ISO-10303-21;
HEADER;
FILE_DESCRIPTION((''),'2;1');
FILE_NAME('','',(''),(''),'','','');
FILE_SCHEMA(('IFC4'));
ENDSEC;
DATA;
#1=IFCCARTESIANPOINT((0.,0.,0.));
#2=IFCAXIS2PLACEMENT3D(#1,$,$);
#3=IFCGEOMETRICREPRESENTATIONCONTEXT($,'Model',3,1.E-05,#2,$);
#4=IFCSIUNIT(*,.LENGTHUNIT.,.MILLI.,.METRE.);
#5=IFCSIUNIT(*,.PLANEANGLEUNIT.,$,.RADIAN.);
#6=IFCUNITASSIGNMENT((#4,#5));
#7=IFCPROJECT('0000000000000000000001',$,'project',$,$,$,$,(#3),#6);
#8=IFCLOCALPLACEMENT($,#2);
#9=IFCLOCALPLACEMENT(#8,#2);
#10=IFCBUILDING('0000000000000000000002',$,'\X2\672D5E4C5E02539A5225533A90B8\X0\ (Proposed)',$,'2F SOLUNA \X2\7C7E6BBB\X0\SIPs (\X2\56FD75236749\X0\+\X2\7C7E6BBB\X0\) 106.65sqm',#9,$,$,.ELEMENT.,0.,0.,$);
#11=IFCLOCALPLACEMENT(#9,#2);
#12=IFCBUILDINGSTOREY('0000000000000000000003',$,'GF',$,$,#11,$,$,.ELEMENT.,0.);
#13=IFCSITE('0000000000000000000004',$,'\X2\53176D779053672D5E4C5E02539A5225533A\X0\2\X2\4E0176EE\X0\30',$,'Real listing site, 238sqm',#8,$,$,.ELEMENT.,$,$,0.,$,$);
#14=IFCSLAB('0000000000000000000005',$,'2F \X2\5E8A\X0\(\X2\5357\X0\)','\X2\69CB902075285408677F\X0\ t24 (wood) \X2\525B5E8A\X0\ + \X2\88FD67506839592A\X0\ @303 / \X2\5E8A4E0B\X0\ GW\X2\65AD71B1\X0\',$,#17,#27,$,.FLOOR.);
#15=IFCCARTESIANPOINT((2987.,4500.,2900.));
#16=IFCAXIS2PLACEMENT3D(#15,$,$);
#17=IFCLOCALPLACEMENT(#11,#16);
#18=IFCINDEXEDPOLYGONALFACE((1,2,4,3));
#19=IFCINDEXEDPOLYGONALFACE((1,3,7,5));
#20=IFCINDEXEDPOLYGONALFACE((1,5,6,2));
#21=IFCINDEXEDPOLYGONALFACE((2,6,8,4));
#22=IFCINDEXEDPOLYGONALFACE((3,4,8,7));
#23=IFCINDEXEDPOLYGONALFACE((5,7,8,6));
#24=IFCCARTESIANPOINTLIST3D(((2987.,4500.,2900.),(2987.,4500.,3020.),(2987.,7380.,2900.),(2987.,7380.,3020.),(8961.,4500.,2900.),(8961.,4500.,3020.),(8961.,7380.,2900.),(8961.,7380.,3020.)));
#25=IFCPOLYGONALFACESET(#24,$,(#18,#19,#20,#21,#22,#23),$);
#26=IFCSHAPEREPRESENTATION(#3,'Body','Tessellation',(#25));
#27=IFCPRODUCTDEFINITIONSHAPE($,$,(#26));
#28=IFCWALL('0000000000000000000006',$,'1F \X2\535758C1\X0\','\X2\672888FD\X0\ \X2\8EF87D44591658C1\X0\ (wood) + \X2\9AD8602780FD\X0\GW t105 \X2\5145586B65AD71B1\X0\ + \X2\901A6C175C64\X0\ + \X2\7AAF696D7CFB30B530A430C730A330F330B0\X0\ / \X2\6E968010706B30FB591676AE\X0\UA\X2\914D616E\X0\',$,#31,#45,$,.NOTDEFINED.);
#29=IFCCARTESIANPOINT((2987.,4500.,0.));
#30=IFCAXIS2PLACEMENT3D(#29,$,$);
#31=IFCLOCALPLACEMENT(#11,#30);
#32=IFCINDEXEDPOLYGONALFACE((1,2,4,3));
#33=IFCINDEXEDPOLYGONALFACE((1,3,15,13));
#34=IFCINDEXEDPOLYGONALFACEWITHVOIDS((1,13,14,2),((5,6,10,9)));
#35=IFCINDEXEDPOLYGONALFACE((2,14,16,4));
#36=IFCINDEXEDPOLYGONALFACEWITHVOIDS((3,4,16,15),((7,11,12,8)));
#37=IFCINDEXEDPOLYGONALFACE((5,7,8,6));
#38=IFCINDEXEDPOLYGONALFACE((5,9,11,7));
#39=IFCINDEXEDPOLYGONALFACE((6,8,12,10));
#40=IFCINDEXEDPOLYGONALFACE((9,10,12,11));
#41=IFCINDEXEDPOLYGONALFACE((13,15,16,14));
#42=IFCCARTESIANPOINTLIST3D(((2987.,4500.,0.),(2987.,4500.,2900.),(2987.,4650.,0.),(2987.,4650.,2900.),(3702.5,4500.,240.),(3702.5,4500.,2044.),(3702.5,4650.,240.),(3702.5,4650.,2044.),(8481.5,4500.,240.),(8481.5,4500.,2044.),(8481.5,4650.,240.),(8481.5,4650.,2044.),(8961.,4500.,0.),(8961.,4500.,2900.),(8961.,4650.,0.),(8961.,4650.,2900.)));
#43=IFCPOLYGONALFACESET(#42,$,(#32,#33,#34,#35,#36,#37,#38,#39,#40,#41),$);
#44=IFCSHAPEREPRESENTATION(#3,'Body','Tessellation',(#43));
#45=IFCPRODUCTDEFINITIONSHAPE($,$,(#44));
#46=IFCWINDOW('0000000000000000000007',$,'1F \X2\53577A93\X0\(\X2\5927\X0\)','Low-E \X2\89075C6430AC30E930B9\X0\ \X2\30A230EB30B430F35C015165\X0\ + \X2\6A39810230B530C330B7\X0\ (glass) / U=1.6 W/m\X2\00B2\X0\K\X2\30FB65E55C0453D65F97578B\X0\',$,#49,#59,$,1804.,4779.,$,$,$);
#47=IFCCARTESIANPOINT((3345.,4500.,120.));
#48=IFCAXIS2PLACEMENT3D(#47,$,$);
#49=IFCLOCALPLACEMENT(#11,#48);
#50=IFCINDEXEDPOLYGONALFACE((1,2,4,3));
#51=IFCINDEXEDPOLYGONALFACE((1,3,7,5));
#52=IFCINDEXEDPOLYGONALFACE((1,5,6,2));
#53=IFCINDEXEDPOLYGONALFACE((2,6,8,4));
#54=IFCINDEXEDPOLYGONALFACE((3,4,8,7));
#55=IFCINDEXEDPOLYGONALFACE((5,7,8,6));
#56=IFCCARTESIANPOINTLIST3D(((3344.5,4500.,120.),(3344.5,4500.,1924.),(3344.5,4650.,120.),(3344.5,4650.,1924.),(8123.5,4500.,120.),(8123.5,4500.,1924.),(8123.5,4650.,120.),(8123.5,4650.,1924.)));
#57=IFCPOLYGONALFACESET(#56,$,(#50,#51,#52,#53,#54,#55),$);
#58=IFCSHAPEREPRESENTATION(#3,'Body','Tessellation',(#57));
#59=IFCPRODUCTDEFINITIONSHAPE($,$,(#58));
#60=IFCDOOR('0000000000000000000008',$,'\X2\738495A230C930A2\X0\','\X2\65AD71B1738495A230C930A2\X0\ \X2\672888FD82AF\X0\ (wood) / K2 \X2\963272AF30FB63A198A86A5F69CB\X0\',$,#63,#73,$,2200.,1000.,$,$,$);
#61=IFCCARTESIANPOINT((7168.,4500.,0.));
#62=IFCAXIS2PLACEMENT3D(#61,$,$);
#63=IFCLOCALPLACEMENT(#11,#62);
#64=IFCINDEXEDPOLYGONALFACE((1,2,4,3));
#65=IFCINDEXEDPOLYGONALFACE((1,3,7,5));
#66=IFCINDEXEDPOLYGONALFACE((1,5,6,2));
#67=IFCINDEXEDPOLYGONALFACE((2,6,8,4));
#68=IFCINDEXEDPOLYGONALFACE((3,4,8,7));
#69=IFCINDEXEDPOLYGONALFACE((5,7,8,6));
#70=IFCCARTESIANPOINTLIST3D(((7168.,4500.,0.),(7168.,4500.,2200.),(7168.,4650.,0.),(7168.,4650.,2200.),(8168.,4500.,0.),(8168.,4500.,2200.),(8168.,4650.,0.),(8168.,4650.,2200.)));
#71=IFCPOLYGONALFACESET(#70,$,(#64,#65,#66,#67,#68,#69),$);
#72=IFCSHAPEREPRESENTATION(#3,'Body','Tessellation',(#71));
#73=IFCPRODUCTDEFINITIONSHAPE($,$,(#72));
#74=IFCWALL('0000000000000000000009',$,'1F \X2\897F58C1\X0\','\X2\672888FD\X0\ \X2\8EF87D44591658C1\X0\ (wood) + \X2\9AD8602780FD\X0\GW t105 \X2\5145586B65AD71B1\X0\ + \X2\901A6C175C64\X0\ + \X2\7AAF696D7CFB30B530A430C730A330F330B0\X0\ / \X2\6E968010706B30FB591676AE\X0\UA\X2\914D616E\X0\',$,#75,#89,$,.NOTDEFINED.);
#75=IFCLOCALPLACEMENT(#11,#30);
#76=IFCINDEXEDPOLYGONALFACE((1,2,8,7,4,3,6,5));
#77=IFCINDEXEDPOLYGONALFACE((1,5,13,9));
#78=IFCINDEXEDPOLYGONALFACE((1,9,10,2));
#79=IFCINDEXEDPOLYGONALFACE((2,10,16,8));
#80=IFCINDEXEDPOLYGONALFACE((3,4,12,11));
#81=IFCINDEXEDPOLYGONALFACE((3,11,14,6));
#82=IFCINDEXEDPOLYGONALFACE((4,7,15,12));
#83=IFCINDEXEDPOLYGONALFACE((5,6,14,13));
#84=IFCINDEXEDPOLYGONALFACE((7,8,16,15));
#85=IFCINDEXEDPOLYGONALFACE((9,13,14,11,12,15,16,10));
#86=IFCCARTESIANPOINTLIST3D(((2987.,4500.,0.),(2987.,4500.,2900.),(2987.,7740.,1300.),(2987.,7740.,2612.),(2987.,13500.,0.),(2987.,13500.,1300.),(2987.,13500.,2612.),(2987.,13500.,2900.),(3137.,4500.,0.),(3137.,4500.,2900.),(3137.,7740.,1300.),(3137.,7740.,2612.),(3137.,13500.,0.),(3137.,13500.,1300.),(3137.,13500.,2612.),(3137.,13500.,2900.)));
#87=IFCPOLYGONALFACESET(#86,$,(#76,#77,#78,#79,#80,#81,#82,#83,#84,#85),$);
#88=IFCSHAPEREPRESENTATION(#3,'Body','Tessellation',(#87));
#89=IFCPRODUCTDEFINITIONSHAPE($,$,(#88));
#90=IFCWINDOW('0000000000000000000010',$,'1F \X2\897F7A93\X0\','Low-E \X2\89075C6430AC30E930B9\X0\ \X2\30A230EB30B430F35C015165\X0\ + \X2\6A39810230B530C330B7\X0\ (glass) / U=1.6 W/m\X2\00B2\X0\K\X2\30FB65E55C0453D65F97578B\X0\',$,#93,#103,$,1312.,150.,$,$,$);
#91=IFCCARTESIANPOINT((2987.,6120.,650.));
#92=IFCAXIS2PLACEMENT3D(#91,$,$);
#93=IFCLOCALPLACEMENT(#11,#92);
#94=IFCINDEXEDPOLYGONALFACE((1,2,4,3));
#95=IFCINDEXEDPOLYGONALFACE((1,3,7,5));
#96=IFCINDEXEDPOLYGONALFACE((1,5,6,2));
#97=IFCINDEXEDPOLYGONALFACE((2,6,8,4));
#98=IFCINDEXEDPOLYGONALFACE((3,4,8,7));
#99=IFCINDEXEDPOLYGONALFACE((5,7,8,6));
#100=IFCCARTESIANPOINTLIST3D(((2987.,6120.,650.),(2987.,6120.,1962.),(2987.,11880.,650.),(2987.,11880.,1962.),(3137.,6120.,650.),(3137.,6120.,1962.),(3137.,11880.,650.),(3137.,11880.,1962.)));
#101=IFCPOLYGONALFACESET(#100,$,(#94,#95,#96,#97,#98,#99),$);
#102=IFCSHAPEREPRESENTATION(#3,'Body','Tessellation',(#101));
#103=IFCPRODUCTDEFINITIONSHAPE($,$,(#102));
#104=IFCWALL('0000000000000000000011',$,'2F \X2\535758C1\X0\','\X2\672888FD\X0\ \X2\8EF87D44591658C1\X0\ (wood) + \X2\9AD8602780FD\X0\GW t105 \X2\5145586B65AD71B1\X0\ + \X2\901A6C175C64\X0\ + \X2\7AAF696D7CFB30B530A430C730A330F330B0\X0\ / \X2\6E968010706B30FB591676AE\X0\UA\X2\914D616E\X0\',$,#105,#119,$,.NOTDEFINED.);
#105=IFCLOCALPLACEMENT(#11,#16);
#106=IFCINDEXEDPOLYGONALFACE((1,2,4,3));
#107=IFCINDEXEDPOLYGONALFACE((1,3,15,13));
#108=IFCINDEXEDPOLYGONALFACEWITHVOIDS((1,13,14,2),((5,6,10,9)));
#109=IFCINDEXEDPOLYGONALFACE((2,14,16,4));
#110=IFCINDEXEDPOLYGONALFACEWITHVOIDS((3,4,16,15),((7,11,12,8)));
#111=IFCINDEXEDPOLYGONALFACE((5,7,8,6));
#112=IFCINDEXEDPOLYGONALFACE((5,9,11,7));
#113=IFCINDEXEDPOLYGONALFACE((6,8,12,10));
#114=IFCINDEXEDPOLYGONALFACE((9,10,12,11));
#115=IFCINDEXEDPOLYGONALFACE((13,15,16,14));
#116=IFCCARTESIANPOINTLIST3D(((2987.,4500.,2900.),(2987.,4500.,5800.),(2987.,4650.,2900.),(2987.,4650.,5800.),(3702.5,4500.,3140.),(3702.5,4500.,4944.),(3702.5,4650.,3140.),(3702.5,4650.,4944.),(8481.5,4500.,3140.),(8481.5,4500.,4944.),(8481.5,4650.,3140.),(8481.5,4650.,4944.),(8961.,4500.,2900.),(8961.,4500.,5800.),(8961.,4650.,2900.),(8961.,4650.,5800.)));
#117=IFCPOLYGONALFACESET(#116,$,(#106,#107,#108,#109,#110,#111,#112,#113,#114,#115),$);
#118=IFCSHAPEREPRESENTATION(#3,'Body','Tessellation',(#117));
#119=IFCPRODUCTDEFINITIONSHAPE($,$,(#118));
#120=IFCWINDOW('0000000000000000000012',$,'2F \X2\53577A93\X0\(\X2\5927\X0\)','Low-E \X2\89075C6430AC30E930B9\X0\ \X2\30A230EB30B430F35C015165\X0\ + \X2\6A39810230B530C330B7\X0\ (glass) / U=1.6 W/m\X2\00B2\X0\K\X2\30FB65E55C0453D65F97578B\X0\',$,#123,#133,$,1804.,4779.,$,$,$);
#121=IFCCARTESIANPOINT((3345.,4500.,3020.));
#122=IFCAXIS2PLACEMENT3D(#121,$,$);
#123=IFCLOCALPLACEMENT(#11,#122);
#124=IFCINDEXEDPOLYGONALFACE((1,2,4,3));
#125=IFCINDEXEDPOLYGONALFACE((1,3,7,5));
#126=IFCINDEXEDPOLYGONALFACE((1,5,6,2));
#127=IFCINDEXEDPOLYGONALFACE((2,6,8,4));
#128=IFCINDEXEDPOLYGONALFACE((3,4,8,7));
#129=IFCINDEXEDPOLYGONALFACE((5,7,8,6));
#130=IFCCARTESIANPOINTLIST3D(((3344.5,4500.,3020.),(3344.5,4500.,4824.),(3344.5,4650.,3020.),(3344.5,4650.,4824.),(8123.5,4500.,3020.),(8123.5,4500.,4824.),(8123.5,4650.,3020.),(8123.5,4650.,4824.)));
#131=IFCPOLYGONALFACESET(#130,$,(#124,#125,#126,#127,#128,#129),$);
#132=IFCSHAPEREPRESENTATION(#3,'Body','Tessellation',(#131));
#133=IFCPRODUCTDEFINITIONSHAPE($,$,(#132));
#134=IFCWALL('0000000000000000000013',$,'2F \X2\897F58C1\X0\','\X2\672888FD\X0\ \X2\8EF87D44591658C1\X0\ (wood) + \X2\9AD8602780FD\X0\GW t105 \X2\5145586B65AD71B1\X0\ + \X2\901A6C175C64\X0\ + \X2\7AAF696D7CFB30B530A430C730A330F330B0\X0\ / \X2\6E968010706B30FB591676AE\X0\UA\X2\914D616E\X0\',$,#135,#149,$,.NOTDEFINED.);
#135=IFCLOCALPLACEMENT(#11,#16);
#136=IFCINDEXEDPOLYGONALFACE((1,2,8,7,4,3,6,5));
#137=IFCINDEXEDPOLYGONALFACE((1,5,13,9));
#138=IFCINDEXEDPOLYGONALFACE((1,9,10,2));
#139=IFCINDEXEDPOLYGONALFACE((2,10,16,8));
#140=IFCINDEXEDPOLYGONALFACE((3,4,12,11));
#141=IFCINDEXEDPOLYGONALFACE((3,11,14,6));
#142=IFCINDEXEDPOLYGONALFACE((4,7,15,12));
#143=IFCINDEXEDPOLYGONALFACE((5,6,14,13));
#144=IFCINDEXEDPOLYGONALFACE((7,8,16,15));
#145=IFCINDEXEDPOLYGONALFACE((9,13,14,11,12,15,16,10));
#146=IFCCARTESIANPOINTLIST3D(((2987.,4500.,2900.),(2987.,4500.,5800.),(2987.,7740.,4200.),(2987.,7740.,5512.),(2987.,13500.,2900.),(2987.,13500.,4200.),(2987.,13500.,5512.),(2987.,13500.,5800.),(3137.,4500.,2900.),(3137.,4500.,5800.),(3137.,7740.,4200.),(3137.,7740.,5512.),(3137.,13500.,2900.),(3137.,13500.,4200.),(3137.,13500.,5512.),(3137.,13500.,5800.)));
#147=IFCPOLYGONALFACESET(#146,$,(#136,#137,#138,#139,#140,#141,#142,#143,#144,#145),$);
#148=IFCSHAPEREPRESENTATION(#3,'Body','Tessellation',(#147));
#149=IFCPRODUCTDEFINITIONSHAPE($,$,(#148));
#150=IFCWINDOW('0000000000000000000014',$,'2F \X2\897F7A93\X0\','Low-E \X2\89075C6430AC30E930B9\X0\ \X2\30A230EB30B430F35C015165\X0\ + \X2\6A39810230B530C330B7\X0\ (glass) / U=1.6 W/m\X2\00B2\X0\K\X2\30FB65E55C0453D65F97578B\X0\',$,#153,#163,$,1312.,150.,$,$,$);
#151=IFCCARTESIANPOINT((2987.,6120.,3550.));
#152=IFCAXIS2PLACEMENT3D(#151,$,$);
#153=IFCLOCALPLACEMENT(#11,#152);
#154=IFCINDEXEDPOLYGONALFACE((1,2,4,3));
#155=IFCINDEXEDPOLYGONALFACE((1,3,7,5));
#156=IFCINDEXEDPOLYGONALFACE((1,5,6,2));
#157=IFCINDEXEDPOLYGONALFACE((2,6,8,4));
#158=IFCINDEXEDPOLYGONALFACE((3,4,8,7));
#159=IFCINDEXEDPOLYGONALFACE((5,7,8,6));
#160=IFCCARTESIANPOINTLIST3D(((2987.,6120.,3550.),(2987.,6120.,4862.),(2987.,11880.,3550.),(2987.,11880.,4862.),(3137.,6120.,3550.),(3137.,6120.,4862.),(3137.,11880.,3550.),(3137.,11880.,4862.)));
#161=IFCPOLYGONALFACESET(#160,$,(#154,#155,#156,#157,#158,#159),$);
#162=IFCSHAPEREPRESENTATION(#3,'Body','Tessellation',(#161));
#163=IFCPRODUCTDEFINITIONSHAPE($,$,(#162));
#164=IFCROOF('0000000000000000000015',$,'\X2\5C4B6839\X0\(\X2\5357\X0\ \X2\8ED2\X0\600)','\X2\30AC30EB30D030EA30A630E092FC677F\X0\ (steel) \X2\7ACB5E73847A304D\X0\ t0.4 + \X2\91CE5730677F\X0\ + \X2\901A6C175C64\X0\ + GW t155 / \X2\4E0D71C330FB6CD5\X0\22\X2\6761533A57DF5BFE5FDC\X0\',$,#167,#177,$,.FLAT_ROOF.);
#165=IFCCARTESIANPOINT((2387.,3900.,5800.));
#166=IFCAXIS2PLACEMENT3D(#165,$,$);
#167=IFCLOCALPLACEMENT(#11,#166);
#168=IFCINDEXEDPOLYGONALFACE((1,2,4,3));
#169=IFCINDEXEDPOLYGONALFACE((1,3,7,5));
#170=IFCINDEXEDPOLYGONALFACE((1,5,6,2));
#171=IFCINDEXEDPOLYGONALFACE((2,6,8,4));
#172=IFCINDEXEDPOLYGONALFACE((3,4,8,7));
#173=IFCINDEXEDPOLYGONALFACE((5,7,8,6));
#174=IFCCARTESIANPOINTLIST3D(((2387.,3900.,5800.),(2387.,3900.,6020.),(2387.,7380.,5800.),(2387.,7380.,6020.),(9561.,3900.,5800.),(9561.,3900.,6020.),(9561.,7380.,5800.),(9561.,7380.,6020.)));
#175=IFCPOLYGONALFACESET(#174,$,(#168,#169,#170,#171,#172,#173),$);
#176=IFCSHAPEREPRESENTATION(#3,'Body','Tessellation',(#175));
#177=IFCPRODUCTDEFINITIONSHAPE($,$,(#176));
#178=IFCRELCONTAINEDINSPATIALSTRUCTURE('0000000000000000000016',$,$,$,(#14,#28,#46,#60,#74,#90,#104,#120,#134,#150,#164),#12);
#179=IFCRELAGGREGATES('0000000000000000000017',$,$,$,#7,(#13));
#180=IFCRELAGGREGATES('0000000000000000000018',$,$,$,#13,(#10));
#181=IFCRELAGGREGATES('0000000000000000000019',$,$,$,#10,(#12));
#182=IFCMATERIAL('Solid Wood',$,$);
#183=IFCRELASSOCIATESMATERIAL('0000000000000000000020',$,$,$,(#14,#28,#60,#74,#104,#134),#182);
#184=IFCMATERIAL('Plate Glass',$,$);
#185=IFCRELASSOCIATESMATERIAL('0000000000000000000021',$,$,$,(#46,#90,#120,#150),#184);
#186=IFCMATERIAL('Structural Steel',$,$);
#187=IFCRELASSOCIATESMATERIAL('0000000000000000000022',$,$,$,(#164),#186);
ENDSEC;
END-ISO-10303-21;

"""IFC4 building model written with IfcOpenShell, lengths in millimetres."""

from ifc_helpers import new_model, si_unit, frame, frame_2d, origin, place, context, project, spatial, rectangle, extrude, material, element, fill, save


model = new_model("IFC4")

# Units and contexts
model_context = context("Model", 3, precision=1e-05, world=origin())
ifc_project = project(units=[si_unit("LENGTHUNIT", "METRE", prefix="MILLI"), si_unit("PLANEANGLEUNIT", "RADIAN")], contexts=[model_context])

# Site, building, storey
site_placement = place(None, origin())
site = spatial("IfcSite", under=ifc_project, at=site_placement, Name="北海道札幌市厚別区2丁目30", ObjectType="Real listing site, 238sqm", CompositionType="ELEMENT", RefElevation=0.0)
building_placement = place(site_placement, origin())
building = spatial("IfcBuilding", under=site, at=building_placement, Name="札幌市厚別区邸 (Proposed)", ObjectType="2F SOLUNA 籾殻SIPs (国産杉+籾殻) 106.65sqm", CompositionType="ELEMENT", ElevationOfRefHeight=0.0, ElevationOfTerrain=0.0)
storey_placement = place(building_placement, origin())
storey = spatial("IfcBuildingStorey", under=building, at=storey_placement, Name="GF", CompositionType="ELEMENT", Elevation=0.0)

# Slab
ifc_material_1 = material(Name="Solid Wood")
slab_1_placement = place(storey_placement, frame((2987.0, 4500.0, 2900.0)))
element("IfcSlab", 1, at=slab_1_placement, inside=storey, material=ifc_material_1, Name="2F 床(南)", Description="構造用合板 t24 (wood) 剛床 + 製材根太 @303 / 床下 GW断熱", PredefinedType="FLOOR", context=model_context, shape_type="SweptSolid", body=[
    extrude(rectangle(XDim=5974.0, YDim=2880.0, at=frame_2d((2987.0, 1440.0))), frame((2987.0, 4500.0, 2900.0)), (0.0, 0.0, 1.0), 120.0),
])

# Wall, openings, window, door
wall_1_placement = place(storey_placement, frame((2987.0, 4500.0, 0.0)))
wall_1 = element("IfcWall", 2, at=wall_1_placement, inside=storey, material=ifc_material_1, Name="1F 南壁", Description="木製 軸組外壁 (wood) + 高性能GW t105 充填断熱 + 通気層 + 窯業系サイディング / 準耐火・外皮UA配慮", PredefinedType="NOTDEFINED", context=model_context, shape_type="SweptSolid", body=[
    extrude(rectangle(XDim=5974.0, YDim=150.0, at=frame_2d((2987.0, 75.0))), frame((2987.0, 4500.0, 0.0)), (0.0, 0.0, 1.0), 2900.0),
])
opening_1_placement = place(storey_placement, frame((3345.0, 4500.0, 120.0)))
opening_1 = element("IfcOpeningElement", 3, at=opening_1_placement, cuts=wall_1, PredefinedType="NOTDEFINED", context=model_context, shape_type="SweptSolid", body=[
    extrude(rectangle(XDim=4779.0, YDim=150.0, at=frame_2d((2389.0, 75.0))), frame((3345.0, 4500.0, 120.0)), (0.0, 0.0, 1.0), 1804.0),
])
opening_2_placement = place(storey_placement, frame((7168.0, 4500.0, 0.0)))
opening_2 = element("IfcOpeningElement", 4, at=opening_2_placement, cuts=wall_1, PredefinedType="NOTDEFINED", context=model_context, shape_type="SweptSolid", body=[
    extrude(rectangle(XDim=1000.0, YDim=150.0, at=frame_2d((500.0, 75.0))), frame((7168.0, 4500.0, 0.0)), (0.0, 0.0, 1.0), 2200.0),
])
ifc_material_2 = material(Name="Plate Glass")
window_1_placement = place(storey_placement, frame((3345.0, 4500.0, 120.0)))
window_1 = element("IfcWindow", 5, at=window_1_placement, inside=storey, material=ifc_material_2, Name="1F 南窓(大)", Description="Low-E 複層ガラス アルゴン封入 + 樹脂サッシ (glass) / U=1.6 W/m²K・日射取得型", OverallHeight=1804.0, OverallWidth=4779.0, context=model_context, shape_type="SweptSolid", body=[
    extrude(rectangle(XDim=4779.0, YDim=150.0, at=frame_2d((2389.0, 75.0))), frame((3345.0, 4500.0, 120.0)), (0.0, 0.0, 1.0), 1804.0),
])
fill(opening_1, window_1)
door_placement = place(storey_placement, frame((7168.0, 4500.0, 0.0)))
door = element("IfcDoor", 6, at=door_placement, inside=storey, material=ifc_material_1, Name="玄関ドア", Description="断熱玄関ドア 木製芯 (wood) / K2 防犯・採風機構", OverallHeight=2200.0, OverallWidth=1000.0, context=model_context, shape_type="SweptSolid", body=[
    extrude(rectangle(XDim=1000.0, YDim=150.0, at=frame_2d((500.0, 75.0))), frame((7168.0, 4500.0, 0.0)), (0.0, 0.0, 1.0), 2200.0),
])
fill(opening_2, door)

# Walls, openings, windows
wall_2_placement = place(storey_placement, frame((2987.0, 4500.0, 0.0)))
wall_2 = element("IfcWall", 7, at=wall_2_placement, inside=storey, material=ifc_material_1, Name="1F 西壁", Description="木製 軸組外壁 (wood) + 高性能GW t105 充填断熱 + 通気層 + 窯業系サイディング / 準耐火・外皮UA配慮", PredefinedType="NOTDEFINED", context=model_context, shape_type="SweptSolid", body=[
    extrude(rectangle(XDim=150.0, YDim=9000.0, at=frame_2d((75.0, 4500.0))), frame((2987.0, 4500.0, 0.0)), (0.0, 0.0, 1.0), 2900.0),
])
opening_3_placement = place(storey_placement, frame((2987.0, 6120.0, 650.0)))
opening_3 = element("IfcOpeningElement", 8, at=opening_3_placement, cuts=wall_2, PredefinedType="NOTDEFINED", context=model_context, shape_type="SweptSolid", body=[
    extrude(rectangle(XDim=150.0, YDim=5760.0, at=frame_2d((75.0, 2880.0))), frame((2987.0, 6120.0, 650.0)), (0.0, 0.0, 1.0), 1312.0),
])
window_2_placement = place(storey_placement, frame((2987.0, 6120.0, 650.0)))
window_2 = element("IfcWindow", 9, at=window_2_placement, inside=storey, material=ifc_material_2, Name="1F 西窓", Description="Low-E 複層ガラス アルゴン封入 + 樹脂サッシ (glass) / U=1.6 W/m²K・日射取得型", OverallHeight=1312.0, OverallWidth=150.0, context=model_context, shape_type="SweptSolid", body=[
    extrude(rectangle(XDim=150.0, YDim=5760.0, at=frame_2d((75.0, 2880.0))), frame((2987.0, 6120.0, 650.0)), (0.0, 0.0, 1.0), 1312.0),
])
fill(opening_3, window_2)
wall_3_placement = place(storey_placement, frame((2987.0, 4500.0, 2900.0)))
wall_3 = element("IfcWall", 10, at=wall_3_placement, inside=storey, material=ifc_material_1, Name="2F 南壁", Description="木製 軸組外壁 (wood) + 高性能GW t105 充填断熱 + 通気層 + 窯業系サイディング / 準耐火・外皮UA配慮", PredefinedType="NOTDEFINED", context=model_context, shape_type="SweptSolid", body=[
    extrude(rectangle(XDim=5974.0, YDim=150.0, at=frame_2d((2987.0, 75.0))), frame((2987.0, 4500.0, 2900.0)), (0.0, 0.0, 1.0), 2900.0),
])
opening_4_placement = place(storey_placement, frame((3345.0, 4500.0, 3020.0)))
opening_4 = element("IfcOpeningElement", 11, at=opening_4_placement, cuts=wall_3, PredefinedType="NOTDEFINED", context=model_context, shape_type="SweptSolid", body=[
    extrude(rectangle(XDim=4779.0, YDim=150.0, at=frame_2d((2389.0, 75.0))), frame((3345.0, 4500.0, 3020.0)), (0.0, 0.0, 1.0), 1804.0),
])
window_3_placement = place(storey_placement, frame((3345.0, 4500.0, 3020.0)))
window_3 = element("IfcWindow", 12, at=window_3_placement, inside=storey, material=ifc_material_2, Name="2F 南窓(大)", Description="Low-E 複層ガラス アルゴン封入 + 樹脂サッシ (glass) / U=1.6 W/m²K・日射取得型", OverallHeight=1804.0, OverallWidth=4779.0, context=model_context, shape_type="SweptSolid", body=[
    extrude(rectangle(XDim=4779.0, YDim=150.0, at=frame_2d((2389.0, 75.0))), frame((3345.0, 4500.0, 3020.0)), (0.0, 0.0, 1.0), 1804.0),
])
fill(opening_4, window_3)
wall_4_placement = place(storey_placement, frame((2987.0, 4500.0, 2900.0)))
wall_4 = element("IfcWall", 13, at=wall_4_placement, inside=storey, material=ifc_material_1, Name="2F 西壁", Description="木製 軸組外壁 (wood) + 高性能GW t105 充填断熱 + 通気層 + 窯業系サイディング / 準耐火・外皮UA配慮", PredefinedType="NOTDEFINED", context=model_context, shape_type="SweptSolid", body=[
    extrude(rectangle(XDim=150.0, YDim=9000.0, at=frame_2d((75.0, 4500.0))), frame((2987.0, 4500.0, 2900.0)), (0.0, 0.0, 1.0), 2900.0),
])
opening_5_placement = place(storey_placement, frame((2987.0, 6120.0, 3550.0)))
opening_5 = element("IfcOpeningElement", 14, at=opening_5_placement, cuts=wall_4, PredefinedType="NOTDEFINED", context=model_context, shape_type="SweptSolid", body=[
    extrude(rectangle(XDim=150.0, YDim=5760.0, at=frame_2d((75.0, 2880.0))), frame((2987.0, 6120.0, 3550.0)), (0.0, 0.0, 1.0), 1312.0),
])
window_4_placement = place(storey_placement, frame((2987.0, 6120.0, 3550.0)))
window_4 = element("IfcWindow", 15, at=window_4_placement, inside=storey, material=ifc_material_2, Name="2F 西窓", Description="Low-E 複層ガラス アルゴン封入 + 樹脂サッシ (glass) / U=1.6 W/m²K・日射取得型", OverallHeight=1312.0, OverallWidth=150.0, context=model_context, shape_type="SweptSolid", body=[
    extrude(rectangle(XDim=150.0, YDim=5760.0, at=frame_2d((75.0, 2880.0))), frame((2987.0, 6120.0, 3550.0)), (0.0, 0.0, 1.0), 1312.0),
])
fill(opening_5, window_4)

# Roof
ifc_material_3 = material(Name="Structural Steel")
roof_1_placement = place(storey_placement, frame((2387.0, 3900.0, 5800.0)))
element("IfcRoof", 16, at=roof_1_placement, inside=storey, material=ifc_material_3, Name="屋根(南 軒600)", Description="ガルバリウム鋼板 (steel) 立平葺き t0.4 + 野地板 + 通気層 + GW t155 / 不燃・法22条区域対応", PredefinedType="FLAT_ROOF", context=model_context, shape_type="SweptSolid", body=[
    extrude(rectangle(XDim=7174.0, YDim=3480.0, at=frame_2d((3587.0, 1740.0))), frame((2387.0, 3900.0, 5800.0)), (0.0, 0.0, 1.0), 220.0),
])

save(model, "model.ifc")
